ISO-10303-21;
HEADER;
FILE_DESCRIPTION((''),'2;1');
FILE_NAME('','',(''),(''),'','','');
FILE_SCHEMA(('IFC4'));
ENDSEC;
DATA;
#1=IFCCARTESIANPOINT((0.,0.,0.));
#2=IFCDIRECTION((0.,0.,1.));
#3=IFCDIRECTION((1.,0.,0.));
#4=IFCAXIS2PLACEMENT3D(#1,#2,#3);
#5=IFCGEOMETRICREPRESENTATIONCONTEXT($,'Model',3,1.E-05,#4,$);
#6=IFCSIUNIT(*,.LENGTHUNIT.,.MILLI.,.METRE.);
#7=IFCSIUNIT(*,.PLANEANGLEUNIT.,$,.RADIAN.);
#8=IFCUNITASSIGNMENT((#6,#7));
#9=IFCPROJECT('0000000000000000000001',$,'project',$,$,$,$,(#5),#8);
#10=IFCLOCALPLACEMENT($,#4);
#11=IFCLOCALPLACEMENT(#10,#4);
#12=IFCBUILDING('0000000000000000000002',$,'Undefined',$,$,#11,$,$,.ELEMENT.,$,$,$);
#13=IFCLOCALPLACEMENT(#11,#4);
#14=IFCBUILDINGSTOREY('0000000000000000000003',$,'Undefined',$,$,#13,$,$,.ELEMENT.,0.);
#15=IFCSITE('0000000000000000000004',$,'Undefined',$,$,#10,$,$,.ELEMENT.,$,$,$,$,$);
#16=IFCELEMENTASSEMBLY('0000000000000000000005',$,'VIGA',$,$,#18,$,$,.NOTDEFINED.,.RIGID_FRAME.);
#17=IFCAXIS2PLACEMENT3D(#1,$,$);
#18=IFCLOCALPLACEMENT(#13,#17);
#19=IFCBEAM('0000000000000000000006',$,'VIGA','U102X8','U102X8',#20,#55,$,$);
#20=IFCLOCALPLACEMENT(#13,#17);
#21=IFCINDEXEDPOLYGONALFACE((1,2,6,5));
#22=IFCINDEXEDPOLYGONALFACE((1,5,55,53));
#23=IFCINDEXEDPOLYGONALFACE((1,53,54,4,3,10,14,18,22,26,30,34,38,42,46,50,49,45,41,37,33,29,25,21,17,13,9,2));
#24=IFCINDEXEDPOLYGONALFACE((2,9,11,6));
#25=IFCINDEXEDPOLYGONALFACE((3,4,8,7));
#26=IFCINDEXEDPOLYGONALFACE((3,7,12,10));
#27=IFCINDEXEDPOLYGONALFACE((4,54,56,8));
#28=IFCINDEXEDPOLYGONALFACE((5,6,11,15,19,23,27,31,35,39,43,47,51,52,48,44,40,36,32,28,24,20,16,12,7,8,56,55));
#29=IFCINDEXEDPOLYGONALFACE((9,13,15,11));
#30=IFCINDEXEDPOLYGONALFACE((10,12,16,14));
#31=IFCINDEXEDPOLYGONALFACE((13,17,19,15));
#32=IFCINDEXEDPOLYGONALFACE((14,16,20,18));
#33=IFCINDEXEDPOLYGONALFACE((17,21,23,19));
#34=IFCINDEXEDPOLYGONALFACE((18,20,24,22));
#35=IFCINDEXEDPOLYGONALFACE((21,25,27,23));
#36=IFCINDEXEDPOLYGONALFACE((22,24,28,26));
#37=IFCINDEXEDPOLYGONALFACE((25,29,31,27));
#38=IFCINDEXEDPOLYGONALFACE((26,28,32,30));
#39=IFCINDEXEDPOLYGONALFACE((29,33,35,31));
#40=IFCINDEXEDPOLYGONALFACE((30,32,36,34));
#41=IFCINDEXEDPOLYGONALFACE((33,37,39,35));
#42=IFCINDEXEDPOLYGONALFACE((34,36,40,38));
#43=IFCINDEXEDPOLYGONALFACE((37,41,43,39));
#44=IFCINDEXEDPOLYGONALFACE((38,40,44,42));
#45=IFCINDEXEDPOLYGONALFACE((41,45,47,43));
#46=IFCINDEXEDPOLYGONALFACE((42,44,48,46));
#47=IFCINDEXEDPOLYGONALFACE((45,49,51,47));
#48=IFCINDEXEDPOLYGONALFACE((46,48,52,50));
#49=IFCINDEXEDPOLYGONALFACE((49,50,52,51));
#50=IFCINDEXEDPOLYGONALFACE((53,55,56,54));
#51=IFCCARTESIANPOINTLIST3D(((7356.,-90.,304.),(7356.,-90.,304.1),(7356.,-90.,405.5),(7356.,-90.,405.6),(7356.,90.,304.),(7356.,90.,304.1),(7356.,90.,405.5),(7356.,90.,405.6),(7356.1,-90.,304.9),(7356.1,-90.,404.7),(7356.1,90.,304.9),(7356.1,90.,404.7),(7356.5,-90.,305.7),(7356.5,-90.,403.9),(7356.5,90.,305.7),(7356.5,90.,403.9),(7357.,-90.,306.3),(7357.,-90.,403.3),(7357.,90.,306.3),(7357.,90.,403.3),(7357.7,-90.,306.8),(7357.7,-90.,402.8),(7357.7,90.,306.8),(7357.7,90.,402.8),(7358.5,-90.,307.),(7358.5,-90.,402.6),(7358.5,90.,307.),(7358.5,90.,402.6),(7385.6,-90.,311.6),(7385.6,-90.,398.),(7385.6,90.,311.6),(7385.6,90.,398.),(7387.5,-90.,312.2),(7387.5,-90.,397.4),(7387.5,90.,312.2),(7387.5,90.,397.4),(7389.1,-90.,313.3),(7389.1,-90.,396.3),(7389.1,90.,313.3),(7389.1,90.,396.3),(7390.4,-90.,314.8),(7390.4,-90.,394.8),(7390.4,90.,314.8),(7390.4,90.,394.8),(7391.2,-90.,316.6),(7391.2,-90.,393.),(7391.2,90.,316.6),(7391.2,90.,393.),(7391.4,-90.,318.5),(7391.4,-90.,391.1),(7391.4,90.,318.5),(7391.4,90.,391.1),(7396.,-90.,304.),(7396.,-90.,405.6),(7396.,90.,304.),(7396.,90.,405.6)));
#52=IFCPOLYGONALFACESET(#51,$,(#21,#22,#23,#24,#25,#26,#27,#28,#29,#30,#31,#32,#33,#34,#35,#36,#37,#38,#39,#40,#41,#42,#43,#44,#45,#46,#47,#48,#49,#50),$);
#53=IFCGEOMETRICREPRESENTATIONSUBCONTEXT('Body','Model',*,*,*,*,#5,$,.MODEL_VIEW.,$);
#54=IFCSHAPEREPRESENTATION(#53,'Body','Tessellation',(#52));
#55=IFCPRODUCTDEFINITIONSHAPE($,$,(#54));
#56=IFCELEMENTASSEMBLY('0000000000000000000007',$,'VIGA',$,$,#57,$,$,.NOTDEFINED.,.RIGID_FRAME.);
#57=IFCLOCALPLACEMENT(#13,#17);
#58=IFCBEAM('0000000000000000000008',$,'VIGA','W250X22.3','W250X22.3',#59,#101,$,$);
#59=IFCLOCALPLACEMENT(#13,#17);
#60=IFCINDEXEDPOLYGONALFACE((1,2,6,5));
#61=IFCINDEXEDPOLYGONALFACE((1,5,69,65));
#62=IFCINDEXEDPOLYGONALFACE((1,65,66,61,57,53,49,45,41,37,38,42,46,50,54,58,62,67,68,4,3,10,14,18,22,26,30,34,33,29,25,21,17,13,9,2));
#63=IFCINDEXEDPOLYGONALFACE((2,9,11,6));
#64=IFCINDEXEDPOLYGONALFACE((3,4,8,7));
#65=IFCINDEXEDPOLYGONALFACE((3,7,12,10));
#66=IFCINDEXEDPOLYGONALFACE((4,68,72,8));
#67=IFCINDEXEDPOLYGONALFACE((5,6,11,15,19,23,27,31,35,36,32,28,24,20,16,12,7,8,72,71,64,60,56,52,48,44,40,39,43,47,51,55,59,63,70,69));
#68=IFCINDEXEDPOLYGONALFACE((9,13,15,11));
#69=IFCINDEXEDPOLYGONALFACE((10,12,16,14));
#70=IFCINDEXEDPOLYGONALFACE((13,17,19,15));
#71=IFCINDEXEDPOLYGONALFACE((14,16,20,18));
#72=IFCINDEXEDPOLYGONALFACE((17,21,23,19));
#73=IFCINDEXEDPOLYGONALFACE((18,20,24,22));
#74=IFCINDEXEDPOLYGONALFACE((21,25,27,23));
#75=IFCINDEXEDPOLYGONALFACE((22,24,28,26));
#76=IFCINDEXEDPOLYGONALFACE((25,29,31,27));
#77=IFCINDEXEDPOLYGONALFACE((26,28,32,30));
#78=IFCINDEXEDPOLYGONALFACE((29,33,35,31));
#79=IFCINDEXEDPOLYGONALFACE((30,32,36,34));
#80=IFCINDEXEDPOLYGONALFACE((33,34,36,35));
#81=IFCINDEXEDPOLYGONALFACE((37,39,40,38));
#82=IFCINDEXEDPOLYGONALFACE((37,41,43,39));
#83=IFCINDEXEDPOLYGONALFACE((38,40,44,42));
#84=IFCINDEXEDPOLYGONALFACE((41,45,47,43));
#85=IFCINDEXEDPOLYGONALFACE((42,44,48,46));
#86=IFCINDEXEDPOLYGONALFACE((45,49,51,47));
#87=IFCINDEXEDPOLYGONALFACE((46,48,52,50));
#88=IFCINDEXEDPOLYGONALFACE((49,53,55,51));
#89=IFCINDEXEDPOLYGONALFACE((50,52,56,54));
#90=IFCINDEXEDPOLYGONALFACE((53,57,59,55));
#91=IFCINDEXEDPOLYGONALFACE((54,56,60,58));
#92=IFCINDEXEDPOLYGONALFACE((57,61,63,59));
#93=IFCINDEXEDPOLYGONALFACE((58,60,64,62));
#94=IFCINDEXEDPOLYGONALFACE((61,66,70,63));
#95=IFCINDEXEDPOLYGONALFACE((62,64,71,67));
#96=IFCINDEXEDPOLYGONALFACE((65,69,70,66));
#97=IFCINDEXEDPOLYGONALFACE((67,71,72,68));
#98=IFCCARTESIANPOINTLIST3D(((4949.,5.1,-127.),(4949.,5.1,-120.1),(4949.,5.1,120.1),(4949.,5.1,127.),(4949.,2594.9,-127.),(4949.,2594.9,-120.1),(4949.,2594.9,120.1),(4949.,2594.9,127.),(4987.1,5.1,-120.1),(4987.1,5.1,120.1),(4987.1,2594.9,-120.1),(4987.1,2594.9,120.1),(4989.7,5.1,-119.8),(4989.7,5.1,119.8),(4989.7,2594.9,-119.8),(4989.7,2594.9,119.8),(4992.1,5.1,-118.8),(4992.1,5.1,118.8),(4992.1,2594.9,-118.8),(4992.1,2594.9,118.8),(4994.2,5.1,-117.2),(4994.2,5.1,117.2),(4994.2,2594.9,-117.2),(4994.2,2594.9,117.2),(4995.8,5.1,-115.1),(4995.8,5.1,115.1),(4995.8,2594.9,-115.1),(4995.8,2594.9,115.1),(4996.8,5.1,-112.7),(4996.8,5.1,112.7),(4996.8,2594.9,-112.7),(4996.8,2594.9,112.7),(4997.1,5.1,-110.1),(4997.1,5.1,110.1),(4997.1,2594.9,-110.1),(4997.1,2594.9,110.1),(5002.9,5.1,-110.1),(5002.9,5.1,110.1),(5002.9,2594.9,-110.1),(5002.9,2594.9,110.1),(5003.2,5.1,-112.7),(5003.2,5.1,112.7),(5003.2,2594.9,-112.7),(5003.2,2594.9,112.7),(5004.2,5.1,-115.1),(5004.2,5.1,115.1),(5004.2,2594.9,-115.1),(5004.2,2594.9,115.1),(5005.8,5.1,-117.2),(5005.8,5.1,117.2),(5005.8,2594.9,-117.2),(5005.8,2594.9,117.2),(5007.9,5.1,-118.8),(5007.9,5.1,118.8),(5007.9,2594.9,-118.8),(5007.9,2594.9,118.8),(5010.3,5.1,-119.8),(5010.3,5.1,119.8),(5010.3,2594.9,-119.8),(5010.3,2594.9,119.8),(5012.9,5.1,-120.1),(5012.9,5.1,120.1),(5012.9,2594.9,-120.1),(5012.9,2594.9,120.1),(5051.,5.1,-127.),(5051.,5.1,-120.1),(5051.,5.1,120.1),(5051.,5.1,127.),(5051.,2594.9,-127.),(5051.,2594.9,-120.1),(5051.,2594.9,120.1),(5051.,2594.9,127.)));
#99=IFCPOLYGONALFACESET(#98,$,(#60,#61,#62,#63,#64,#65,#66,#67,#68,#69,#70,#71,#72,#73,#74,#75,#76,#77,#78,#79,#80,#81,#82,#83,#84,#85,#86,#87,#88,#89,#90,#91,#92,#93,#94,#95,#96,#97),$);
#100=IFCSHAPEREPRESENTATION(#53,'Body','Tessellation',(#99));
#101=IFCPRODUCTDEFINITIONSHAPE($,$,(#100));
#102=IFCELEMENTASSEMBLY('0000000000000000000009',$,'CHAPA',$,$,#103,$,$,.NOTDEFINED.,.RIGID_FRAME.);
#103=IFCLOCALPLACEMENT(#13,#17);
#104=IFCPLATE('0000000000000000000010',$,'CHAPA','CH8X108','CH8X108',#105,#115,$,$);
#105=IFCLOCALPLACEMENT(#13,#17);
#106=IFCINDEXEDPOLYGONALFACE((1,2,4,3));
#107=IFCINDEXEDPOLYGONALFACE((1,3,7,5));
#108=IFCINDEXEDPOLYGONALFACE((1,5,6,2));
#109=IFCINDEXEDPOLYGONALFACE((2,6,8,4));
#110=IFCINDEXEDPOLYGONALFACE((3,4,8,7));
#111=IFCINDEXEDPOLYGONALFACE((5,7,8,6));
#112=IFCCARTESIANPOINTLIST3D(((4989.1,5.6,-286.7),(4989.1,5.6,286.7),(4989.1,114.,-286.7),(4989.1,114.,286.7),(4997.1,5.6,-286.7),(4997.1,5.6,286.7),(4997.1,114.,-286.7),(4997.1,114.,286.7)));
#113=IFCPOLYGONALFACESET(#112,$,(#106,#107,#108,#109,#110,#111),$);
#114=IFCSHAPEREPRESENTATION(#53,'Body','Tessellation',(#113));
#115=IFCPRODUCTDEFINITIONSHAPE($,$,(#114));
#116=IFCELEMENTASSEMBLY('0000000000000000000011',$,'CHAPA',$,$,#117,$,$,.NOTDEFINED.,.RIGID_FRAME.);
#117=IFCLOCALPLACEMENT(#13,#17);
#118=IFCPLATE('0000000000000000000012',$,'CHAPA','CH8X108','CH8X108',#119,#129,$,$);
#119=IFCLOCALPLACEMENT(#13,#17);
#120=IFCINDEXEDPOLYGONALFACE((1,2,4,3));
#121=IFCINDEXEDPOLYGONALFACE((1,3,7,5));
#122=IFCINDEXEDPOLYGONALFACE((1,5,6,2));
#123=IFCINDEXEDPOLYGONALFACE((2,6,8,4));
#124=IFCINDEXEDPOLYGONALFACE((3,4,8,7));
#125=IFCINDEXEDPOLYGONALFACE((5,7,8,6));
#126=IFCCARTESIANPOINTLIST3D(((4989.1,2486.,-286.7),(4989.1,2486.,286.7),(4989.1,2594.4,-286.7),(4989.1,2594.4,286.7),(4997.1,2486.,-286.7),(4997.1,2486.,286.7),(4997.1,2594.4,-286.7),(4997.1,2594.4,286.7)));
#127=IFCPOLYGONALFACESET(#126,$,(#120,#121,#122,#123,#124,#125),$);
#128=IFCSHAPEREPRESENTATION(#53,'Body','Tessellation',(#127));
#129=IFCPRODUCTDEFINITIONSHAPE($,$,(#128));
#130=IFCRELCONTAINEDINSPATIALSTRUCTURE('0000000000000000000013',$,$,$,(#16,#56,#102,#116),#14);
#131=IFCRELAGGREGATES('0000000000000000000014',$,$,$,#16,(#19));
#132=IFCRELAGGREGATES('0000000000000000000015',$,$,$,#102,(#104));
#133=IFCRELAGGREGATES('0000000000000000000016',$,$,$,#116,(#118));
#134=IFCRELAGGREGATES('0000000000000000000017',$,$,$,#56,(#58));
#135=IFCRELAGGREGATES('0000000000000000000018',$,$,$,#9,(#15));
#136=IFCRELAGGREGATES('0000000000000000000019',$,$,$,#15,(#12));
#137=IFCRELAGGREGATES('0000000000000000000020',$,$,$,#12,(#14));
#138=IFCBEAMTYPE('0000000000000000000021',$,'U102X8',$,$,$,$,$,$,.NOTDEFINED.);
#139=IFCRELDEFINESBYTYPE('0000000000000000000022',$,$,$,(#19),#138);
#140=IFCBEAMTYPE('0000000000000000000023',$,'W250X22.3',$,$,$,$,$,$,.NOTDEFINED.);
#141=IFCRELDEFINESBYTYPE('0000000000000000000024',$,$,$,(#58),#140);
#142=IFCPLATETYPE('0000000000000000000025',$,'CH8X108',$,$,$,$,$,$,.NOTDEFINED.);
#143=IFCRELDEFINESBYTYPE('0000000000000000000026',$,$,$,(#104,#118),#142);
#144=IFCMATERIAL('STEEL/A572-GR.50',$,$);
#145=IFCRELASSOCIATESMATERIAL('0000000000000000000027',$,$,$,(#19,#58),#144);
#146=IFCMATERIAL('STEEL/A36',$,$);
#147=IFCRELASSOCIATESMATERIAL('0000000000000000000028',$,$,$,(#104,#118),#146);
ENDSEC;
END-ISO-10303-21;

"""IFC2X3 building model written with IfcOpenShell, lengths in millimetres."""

from ifc_helpers import new_model, si_unit, frame, origin_with_axes, origin_2d_with_axis, place, context, subcontext, project, spatial, polyline, i_section, u_section, outline, extrude, material, type_object, element, aggregate, save


model = new_model("IFC2X3")

# Units and contexts
model_context = context("Model", 3, precision=1e-05, world=origin_with_axes())
body_context = subcontext(model_context, "Body", "Model", "MODEL_VIEW")
ifc_project = project(units=[si_unit("LENGTHUNIT", "METRE", prefix="MILLI"), si_unit("PLANEANGLEUNIT", "RADIAN")], contexts=[model_context])

# Site, building, storey
site_placement = place(None, origin_with_axes())
site = spatial("IfcSite", under=ifc_project, at=site_placement, Name="Undefined", CompositionType="ELEMENT")
building_placement = place(site_placement, origin_with_axes())
building = spatial("IfcBuilding", under=site, at=building_placement, Name="Undefined", CompositionType="ELEMENT")
storey_placement = place(building_placement, origin_with_axes())
storey = spatial("IfcBuildingStorey", under=building, at=storey_placement, Name="Undefined", CompositionType="ELEMENT", Elevation=0.0)

# Element assemblies, beams
ifc_material_1 = material(Name="STEEL/A572-GR.50")
beam_type_1 = type_object("IfcBeamType", Name="U102X8", PredefinedType="NOTDEFINED")
assembly_1_placement = place(storey_placement, origin_with_axes())
assembly_1 = element("IfcElementAssembly", 1, at=assembly_1_placement, inside=storey, Name="VIGA", AssemblyPlace="NOTDEFINED", PredefinedType="RIGID_FRAME")
beam_1_placement = place(assembly_1_placement, frame((7376.0, 90.0, 354.8), z_axis=(0.0, 0.0, 1.0), x_axis=(0.0, -1.0, 0.0)))
beam_1 = element("IfcBeam", 2, at=beam_1_placement, type_object=beam_type_1, material=ifc_material_1, Name="VIGA", Description="U102X8", ObjectType="U102X8", context=body_context, shape_type="SweptSolid", body=[
    extrude(u_section(Depth=101.6, FlangeWidth=40.0, WebThickness=4.6, FlangeThickness=6.0, FilletRadius=7.0, EdgeRadius=3.0, FlangeSlope=0.16839, at=origin_2d_with_axis()), frame((180.0, 0.0, 0.0), z_axis=(-1.0, 0.0, 0.0), x_axis=(0.0, -1.0, 0.0)), (0.0, 0.0, 1.0), 180.0),
])
aggregate(assembly_1, [beam_1])
assembly_2_placement = place(storey_placement, origin_with_axes())
assembly_2 = element("IfcElementAssembly", 3, at=assembly_2_placement, inside=storey, Name="VIGA", AssemblyPlace="NOTDEFINED", PredefinedType="RIGID_FRAME")
beam_type_2 = type_object("IfcBeamType", Name="W250X22.3", PredefinedType="NOTDEFINED")
beam_2_placement = place(assembly_2_placement, frame((5000.0, 5.1, 0.0), z_axis=(0.0, 0.0, 1.0), x_axis=(0.0, 1.0, 0.0)))
beam_2 = element("IfcBeam", 4, at=beam_2_placement, type_object=beam_type_2, material=ifc_material_1, Name="VIGA", Description="W250X22.3", ObjectType="W250X22.3", context=body_context, shape_type="SweptSolid", body=[
    extrude(i_section(OverallWidth=102.0, OverallDepth=254.0, WebThickness=5.8, FlangeThickness=6.9, FilletRadius=10.0, at=origin_2d_with_axis()), frame((2589.8, 0.0, 0.0), z_axis=(-1.0, 0.0, 0.0), x_axis=(0.0, -1.0, 0.0)), (0.0, 0.0, 1.0), 2589.8),
])

# Element assemblies, plates
assembly_3_placement = place(storey_placement, origin_with_axes())
assembly_3 = element("IfcElementAssembly", 5, at=assembly_3_placement, inside=storey, Name="CHAPA", AssemblyPlace="NOTDEFINED", PredefinedType="RIGID_FRAME")
ifc_material_2 = material(Name="STEEL/A36")
plate_type = type_object("IfcPlateType", Name="CH8X108", PredefinedType="NOTDEFINED")
plate_1_placement = place(assembly_3_placement, frame((4993.1, 114.0, 286.7), z_axis=(1.0, 0.0, 0.0), x_axis=(0.0, -1.0, 0.0)))
plate_1 = element("IfcPlate", 6, at=plate_1_placement, type_object=plate_type, material=ifc_material_2, Name="CHAPA", Description="CH8X108", ObjectType="CH8X108", context=body_context, shape_type="SweptSolid", body=[
    extrude(outline(polyline([(0.0, 0.0), (108.4, 0.0), (108.4, 573.4), (0.0, 573.4), (0.0, 0.0)])), frame((0.0, 0.0, -4.0), z_axis=(0.0, 0.0, 1.0), x_axis=(1.0, 0.0, 0.0)), (0.0, 0.0, 1.0), 8.0),
])
aggregate(assembly_3, [plate_1])
assembly_4_placement = place(storey_placement, origin_with_axes())
assembly_4 = element("IfcElementAssembly", 7, at=assembly_4_placement, inside=storey, Name="CHAPA", AssemblyPlace="NOTDEFINED", PredefinedType="RIGID_FRAME")
plate_2_placement = place(assembly_4_placement, frame((4993.1, 2594.4, 286.7), z_axis=(1.0, 0.0, 0.0), x_axis=(0.0, -1.0, 0.0)))
plate_2 = element("IfcPlate", 8, at=plate_2_placement, type_object=plate_type, material=ifc_material_2, Name="CHAPA", Description="CH8X108", ObjectType="CH8X108", context=body_context, shape_type="SweptSolid", body=[
    extrude(outline(polyline([(0.0, 0.0), (108.4, 0.0), (108.4, 573.4), (0.0, 573.4), (0.0, 0.0)])), frame((0.0, 0.0, -4.0), z_axis=(0.0, 0.0, 1.0), x_axis=(1.0, 0.0, 0.0)), (0.0, 0.0, 1.0), 8.0),
])
aggregate(assembly_4, [plate_2])

aggregate(assembly_2, [beam_2])

save(model, "model.ifc")
